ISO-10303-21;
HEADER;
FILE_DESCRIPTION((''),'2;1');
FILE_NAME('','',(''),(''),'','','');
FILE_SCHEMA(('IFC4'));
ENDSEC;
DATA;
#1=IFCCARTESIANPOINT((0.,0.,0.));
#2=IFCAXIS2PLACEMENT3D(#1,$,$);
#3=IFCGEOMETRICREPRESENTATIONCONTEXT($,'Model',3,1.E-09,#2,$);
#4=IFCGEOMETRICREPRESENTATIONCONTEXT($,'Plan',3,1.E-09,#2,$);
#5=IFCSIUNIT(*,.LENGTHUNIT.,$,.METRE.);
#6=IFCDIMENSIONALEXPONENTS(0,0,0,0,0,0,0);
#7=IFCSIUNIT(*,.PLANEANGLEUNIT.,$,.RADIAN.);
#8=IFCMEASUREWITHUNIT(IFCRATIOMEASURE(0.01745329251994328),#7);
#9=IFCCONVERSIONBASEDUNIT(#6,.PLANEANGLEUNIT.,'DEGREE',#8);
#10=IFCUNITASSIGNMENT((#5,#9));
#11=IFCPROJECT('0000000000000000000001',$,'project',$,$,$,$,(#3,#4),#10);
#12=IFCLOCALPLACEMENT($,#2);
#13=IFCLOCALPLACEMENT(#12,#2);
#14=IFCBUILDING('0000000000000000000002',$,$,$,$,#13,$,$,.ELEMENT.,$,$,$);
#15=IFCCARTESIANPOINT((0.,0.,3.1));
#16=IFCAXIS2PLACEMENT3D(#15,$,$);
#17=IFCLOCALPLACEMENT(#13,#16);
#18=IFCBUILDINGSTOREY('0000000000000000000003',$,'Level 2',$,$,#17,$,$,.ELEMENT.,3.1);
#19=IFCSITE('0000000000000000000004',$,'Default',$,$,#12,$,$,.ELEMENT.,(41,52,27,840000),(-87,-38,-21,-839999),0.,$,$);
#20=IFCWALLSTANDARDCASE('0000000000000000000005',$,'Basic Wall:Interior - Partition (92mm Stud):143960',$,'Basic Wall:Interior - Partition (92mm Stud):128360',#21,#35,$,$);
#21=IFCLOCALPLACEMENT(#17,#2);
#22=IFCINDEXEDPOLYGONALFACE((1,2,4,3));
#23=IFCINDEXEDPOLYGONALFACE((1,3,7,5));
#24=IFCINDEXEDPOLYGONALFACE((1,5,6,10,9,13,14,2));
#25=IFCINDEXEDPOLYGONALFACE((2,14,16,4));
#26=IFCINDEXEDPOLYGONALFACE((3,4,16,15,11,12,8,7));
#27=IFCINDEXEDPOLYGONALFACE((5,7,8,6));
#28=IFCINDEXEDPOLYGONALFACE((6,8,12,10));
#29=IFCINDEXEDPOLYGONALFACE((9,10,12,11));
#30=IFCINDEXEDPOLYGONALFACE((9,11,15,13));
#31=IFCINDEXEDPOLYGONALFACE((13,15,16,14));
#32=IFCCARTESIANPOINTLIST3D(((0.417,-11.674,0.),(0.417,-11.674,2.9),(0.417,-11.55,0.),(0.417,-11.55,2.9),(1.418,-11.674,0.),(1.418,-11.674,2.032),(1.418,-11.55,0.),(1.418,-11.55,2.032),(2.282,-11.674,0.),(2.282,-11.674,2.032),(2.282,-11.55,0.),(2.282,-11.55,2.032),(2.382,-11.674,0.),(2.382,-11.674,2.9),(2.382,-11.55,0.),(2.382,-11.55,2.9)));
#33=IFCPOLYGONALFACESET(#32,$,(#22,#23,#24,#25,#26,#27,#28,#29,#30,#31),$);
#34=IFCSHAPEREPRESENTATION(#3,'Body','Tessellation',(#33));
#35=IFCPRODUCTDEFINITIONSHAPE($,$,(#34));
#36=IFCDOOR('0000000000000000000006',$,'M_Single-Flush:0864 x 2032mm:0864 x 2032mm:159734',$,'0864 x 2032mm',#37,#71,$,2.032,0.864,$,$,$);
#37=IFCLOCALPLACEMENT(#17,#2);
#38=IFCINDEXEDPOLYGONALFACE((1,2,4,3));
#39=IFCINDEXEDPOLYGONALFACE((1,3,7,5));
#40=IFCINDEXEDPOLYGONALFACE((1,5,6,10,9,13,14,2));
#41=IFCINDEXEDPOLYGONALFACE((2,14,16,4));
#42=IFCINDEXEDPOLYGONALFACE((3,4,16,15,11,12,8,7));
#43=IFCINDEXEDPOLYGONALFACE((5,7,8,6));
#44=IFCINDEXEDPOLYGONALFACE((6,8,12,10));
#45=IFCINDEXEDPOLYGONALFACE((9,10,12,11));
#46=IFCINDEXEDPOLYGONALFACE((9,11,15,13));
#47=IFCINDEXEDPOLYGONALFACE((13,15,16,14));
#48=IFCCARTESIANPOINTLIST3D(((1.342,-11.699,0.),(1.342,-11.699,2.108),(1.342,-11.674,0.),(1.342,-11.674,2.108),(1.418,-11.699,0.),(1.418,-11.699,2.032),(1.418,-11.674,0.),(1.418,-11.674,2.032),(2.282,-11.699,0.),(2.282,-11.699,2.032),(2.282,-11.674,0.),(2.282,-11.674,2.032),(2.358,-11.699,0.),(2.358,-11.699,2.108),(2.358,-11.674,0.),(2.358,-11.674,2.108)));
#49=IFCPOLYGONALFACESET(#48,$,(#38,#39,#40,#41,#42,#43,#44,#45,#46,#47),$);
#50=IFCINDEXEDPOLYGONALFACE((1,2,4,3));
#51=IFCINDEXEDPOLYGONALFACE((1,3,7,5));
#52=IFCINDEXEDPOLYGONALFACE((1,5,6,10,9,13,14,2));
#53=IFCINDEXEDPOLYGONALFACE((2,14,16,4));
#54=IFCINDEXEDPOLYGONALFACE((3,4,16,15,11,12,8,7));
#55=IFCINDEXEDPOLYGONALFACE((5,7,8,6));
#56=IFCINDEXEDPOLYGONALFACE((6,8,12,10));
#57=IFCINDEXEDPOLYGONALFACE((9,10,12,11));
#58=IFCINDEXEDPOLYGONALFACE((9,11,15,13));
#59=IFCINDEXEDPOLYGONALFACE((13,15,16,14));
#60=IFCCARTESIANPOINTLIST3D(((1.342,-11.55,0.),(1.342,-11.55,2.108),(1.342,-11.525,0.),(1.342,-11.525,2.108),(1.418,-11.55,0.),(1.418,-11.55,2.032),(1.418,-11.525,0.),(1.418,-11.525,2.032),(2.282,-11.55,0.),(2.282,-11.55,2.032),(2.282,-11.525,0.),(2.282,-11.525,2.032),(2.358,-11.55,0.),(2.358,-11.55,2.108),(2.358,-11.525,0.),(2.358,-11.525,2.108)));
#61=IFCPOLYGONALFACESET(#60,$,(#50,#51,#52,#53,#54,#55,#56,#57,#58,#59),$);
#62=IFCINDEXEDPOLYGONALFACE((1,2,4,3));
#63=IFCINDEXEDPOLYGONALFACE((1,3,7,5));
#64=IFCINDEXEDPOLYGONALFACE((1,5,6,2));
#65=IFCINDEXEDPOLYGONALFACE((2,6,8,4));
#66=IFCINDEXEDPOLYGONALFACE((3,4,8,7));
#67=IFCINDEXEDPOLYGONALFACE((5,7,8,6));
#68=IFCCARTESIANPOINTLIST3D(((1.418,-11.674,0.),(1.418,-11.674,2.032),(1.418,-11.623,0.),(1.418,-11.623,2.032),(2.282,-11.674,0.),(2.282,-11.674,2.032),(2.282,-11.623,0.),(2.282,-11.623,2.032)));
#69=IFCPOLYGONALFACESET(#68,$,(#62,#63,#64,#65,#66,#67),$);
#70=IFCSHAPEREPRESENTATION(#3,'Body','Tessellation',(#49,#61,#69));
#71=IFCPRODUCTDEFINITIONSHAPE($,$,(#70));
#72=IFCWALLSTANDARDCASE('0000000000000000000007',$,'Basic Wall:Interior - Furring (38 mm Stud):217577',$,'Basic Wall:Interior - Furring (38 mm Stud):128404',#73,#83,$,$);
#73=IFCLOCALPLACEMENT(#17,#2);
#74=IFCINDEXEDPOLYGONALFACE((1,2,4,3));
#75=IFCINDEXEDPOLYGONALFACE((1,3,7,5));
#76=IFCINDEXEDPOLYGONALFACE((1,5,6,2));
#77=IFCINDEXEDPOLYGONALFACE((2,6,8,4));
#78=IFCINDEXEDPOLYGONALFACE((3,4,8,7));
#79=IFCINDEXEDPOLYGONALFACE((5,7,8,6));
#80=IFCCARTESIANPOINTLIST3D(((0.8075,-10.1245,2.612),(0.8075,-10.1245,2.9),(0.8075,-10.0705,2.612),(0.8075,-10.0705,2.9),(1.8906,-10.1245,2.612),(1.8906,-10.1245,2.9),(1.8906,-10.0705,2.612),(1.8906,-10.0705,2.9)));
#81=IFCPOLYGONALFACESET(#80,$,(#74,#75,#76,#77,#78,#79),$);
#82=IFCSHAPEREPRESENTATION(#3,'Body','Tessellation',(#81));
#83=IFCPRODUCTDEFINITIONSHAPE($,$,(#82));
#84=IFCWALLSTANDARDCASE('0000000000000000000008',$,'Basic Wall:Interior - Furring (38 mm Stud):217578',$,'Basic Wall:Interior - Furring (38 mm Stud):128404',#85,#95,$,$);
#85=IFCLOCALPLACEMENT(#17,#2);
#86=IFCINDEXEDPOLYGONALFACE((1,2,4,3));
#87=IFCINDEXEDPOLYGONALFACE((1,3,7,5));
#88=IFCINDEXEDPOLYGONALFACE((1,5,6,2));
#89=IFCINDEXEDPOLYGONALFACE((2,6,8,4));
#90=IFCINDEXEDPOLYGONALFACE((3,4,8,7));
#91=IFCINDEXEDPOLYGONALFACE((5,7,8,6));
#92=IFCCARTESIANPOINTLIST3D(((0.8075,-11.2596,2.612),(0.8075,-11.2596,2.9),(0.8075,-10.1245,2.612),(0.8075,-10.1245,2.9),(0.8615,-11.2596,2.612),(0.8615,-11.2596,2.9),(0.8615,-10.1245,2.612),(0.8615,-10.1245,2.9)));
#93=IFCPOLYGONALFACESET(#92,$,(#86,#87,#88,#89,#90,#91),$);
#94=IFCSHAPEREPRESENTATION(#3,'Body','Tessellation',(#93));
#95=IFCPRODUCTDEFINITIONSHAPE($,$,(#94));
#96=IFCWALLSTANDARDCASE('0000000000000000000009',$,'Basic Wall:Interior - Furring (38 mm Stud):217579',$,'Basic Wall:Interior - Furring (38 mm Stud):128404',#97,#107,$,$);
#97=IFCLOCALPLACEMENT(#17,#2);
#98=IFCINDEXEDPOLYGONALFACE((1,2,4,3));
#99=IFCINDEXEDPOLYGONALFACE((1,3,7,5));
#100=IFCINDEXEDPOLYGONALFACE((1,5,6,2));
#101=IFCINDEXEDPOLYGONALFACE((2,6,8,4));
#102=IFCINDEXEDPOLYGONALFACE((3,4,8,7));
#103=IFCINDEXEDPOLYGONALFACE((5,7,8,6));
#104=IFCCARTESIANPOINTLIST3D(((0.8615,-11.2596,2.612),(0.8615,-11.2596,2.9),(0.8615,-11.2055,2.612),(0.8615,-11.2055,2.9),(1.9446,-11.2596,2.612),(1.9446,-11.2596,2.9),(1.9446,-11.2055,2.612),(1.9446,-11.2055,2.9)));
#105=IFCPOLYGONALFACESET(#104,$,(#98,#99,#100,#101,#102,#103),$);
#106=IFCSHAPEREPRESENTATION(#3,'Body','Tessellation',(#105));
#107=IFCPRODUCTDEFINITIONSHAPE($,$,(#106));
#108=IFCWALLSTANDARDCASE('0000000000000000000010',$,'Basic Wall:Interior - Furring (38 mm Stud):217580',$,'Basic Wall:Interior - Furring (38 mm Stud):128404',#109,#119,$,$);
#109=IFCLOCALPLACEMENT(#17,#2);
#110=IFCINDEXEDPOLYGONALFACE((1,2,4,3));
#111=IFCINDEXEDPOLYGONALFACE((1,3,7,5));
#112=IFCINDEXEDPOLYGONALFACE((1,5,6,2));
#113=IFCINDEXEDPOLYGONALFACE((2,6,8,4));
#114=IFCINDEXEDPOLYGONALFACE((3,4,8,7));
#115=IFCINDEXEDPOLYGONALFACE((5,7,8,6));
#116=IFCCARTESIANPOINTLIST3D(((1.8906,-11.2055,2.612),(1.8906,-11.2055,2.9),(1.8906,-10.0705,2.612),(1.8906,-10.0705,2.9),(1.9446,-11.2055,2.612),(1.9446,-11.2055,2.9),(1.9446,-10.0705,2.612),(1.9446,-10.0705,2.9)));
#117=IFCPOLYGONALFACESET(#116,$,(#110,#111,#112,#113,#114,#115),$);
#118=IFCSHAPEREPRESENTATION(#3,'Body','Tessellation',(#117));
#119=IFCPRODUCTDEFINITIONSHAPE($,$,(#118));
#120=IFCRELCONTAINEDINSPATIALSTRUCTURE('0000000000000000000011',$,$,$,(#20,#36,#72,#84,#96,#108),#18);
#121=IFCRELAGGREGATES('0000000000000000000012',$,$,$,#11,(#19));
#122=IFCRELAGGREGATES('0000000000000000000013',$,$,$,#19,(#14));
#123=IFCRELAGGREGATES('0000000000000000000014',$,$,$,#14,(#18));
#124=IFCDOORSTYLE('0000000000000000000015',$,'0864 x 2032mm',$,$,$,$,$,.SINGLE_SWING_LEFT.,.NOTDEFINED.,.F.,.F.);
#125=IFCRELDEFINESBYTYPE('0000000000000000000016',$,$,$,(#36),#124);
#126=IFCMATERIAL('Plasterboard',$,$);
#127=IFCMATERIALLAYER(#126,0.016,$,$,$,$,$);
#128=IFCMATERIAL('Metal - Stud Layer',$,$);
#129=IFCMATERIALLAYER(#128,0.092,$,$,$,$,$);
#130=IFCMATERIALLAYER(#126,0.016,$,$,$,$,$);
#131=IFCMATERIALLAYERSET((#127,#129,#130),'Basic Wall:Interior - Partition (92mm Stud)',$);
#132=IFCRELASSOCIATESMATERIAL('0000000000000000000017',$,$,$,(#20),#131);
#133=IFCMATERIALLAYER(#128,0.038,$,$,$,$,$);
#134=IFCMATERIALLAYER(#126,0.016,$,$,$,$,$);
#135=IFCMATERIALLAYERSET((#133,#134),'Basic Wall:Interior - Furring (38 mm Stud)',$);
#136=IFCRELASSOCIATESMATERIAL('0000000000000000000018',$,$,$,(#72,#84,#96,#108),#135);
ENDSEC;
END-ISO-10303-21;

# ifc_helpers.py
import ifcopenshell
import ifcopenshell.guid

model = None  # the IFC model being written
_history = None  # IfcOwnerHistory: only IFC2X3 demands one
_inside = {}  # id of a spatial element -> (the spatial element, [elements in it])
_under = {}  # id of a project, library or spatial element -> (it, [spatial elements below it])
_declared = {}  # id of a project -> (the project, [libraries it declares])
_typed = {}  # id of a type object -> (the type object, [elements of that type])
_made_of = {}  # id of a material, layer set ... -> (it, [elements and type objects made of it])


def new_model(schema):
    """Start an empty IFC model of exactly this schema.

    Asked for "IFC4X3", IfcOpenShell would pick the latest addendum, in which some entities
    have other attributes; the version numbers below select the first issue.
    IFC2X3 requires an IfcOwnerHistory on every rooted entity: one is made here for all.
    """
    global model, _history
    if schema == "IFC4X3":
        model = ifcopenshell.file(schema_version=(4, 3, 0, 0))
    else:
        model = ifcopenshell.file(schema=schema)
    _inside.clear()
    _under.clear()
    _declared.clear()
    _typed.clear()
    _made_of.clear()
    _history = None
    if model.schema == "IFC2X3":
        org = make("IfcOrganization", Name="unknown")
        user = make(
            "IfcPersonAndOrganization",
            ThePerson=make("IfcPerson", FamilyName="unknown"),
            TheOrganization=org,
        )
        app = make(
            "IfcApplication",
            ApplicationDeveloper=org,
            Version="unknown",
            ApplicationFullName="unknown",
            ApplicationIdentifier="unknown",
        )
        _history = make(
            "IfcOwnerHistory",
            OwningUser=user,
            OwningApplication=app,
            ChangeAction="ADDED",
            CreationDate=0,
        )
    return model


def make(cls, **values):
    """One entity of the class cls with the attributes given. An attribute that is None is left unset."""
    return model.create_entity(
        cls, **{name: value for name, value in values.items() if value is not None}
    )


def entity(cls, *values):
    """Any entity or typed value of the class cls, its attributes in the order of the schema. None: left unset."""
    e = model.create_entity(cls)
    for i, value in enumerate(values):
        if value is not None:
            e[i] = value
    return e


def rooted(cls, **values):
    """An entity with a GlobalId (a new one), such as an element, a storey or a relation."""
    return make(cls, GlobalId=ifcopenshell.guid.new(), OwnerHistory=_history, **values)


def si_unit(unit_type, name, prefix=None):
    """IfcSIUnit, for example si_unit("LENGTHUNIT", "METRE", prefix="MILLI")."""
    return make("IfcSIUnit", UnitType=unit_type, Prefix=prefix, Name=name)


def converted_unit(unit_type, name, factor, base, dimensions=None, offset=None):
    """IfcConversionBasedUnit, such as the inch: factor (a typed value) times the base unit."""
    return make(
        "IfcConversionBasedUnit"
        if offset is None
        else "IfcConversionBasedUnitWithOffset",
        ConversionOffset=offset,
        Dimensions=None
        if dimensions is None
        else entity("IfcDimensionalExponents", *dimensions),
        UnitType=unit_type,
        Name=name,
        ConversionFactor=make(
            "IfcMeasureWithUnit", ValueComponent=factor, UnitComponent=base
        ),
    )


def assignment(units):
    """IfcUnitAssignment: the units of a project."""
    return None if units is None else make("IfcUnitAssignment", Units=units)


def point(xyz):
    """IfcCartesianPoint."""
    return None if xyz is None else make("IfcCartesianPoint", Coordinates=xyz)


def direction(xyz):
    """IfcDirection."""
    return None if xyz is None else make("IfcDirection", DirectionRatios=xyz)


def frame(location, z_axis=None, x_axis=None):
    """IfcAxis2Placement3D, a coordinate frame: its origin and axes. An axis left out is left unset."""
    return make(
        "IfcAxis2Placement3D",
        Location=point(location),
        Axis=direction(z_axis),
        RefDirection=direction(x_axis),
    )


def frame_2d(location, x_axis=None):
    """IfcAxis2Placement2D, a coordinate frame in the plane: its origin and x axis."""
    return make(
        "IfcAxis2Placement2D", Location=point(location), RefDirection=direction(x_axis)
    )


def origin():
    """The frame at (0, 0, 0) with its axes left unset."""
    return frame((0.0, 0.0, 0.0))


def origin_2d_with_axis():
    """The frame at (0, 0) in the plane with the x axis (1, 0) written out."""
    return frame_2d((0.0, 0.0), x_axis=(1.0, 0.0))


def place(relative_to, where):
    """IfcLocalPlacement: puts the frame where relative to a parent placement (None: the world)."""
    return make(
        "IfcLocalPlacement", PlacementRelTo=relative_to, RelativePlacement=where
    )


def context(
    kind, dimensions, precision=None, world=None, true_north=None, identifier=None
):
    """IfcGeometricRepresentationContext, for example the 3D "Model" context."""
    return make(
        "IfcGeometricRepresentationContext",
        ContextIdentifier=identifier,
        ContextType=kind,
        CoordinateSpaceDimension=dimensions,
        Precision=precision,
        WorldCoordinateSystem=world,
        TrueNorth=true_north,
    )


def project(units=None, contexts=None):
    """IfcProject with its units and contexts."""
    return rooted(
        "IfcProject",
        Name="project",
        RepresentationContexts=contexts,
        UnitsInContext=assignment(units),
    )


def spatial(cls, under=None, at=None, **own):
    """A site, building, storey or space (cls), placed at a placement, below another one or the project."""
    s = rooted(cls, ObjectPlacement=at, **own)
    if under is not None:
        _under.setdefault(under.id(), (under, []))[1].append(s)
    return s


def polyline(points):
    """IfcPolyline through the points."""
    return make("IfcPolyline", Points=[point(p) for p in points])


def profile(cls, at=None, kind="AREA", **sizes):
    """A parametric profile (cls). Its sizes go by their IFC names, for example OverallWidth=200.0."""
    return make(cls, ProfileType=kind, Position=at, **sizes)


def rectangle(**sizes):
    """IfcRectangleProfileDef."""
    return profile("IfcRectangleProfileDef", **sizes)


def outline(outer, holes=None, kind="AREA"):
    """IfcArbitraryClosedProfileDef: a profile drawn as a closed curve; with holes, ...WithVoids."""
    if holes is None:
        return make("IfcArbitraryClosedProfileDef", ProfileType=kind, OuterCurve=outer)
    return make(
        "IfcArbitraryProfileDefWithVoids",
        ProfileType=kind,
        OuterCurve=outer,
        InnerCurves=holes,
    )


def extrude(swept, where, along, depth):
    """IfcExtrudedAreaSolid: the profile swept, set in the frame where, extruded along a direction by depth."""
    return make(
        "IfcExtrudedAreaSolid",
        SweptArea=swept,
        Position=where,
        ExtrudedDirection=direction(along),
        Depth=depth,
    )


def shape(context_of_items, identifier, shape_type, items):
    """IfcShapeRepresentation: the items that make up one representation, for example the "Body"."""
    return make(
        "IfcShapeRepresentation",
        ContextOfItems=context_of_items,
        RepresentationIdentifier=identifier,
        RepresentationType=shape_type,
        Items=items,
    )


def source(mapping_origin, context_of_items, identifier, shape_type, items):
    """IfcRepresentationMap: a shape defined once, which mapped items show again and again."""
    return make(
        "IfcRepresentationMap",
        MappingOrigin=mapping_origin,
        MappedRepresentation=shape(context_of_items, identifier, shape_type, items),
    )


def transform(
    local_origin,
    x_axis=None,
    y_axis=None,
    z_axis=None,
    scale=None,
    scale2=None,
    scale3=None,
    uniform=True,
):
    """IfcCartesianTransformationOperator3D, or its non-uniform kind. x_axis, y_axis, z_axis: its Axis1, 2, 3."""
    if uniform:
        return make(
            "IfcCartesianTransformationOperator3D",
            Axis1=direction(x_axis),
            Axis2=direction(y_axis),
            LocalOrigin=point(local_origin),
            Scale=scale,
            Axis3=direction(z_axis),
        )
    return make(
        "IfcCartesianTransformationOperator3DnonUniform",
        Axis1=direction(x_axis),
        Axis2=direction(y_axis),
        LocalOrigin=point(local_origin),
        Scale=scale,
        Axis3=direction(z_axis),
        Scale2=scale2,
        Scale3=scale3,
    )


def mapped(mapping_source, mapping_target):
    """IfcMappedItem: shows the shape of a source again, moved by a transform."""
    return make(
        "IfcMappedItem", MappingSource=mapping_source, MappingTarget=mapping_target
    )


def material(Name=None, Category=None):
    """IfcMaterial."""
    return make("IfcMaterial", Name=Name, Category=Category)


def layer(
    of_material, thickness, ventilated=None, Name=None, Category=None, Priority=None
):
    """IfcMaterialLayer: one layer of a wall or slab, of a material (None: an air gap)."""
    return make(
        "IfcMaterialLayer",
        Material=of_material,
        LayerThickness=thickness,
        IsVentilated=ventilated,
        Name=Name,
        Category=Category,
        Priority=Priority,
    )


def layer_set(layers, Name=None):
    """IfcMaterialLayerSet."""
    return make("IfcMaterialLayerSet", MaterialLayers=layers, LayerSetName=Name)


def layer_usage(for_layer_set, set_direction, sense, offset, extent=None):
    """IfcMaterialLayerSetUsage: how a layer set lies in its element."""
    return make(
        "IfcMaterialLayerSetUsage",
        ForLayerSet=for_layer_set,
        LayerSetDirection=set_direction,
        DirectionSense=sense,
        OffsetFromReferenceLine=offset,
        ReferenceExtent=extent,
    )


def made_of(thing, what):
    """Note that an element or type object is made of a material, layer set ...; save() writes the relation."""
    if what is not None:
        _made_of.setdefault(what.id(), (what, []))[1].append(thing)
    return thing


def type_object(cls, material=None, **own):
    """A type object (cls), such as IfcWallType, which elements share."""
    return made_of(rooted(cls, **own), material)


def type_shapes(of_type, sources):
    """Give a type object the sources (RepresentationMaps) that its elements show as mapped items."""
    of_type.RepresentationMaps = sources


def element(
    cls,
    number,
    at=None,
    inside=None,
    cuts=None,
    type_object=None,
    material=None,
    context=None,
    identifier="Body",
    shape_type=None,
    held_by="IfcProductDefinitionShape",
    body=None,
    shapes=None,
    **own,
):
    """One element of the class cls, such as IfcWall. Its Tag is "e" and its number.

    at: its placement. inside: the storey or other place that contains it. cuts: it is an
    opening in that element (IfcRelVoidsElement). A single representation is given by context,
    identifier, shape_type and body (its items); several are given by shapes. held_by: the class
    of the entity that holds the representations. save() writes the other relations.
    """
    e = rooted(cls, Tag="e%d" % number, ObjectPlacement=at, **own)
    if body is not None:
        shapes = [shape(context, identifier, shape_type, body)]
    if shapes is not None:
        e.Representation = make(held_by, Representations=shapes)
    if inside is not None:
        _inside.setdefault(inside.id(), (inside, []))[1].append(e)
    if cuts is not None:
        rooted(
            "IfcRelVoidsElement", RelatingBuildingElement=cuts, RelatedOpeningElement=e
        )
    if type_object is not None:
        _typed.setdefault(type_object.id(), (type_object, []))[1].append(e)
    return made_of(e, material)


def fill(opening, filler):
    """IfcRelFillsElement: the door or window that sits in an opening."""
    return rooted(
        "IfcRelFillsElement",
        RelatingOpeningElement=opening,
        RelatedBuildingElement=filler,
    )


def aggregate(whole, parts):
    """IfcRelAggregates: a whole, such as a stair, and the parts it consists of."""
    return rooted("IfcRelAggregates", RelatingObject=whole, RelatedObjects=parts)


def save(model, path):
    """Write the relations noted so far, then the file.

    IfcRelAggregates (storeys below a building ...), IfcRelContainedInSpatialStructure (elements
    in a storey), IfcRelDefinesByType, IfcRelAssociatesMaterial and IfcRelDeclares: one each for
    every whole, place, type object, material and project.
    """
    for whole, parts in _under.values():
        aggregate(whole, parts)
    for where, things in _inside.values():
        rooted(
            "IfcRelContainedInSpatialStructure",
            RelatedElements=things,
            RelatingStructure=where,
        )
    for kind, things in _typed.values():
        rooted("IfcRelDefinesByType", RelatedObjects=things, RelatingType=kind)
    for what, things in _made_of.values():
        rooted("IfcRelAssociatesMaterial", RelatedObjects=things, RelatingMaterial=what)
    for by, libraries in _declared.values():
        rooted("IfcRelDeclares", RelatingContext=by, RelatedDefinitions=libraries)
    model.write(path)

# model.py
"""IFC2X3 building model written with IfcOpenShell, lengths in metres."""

from ifc_helpers import new_model, entity, si_unit, converted_unit, frame, frame_2d, origin, origin_2d_with_axis, place, context, project, spatial, polyline, rectangle, outline, extrude, source, transform, mapped, material, layer, layer_set, layer_usage, type_object, type_shapes, element, fill, save


model = new_model("IFC2X3")

# Units and contexts
model_context = context("Model", 3, precision=1e-09, world=origin())
plan_context = context("Plan", 3, precision=1e-09, world=origin())
ifc_project = project(units=[si_unit("LENGTHUNIT", "METRE"), converted_unit("PLANEANGLEUNIT", "DEGREE", entity("IfcRatioMeasure", 0.01745329251994328), si_unit("PLANEANGLEUNIT", "RADIAN"), dimensions=[0, 0, 0, 0, 0, 0, 0])], contexts=[model_context, plan_context])

# Site, building, storey
site_placement = place(None, origin())
site = spatial("IfcSite", under=ifc_project, at=site_placement, Name="Default", CompositionType="ELEMENT", RefLatitude=(41, 52, 27, 840000), RefLongitude=(-87, -38, -21, -839999), RefElevation=0.0)
building_placement = place(site_placement, origin())
building = spatial("IfcBuilding", under=site, at=building_placement, CompositionType="ELEMENT")
storey_placement = place(building_placement, frame((0.0, 0.0, 3.1)))
storey = spatial("IfcBuildingStorey", under=building, at=storey_placement, Name="Level 2", CompositionType="ELEMENT", Elevation=3.1)

# Wall, opening, door
ifc_material_1 = material(Name="Plasterboard")
ifc_layer_1 = layer(ifc_material_1, 0.016)
ifc_material_2 = material(Name="Metal - Stud Layer")
ifc_layer_2 = layer(ifc_material_2, 0.092)
ifc_layer_3 = layer(ifc_material_1, 0.016)
ifc_layer_set_1 = layer_set([ifc_layer_1, ifc_layer_2, ifc_layer_3], Name="Basic Wall:Interior - Partition (92mm Stud)")
ifc_layer_usage_1 = layer_usage(ifc_layer_set_1, "AXIS2", "NEGATIVE", 0.062)
wall_1_placement = place(storey_placement, frame((2.382, -11.612, 0.0), z_axis=(0.0, 0.0, 1.0), x_axis=(-1.0, 0.0, 0.0)))
wall_1 = element("IfcWallStandardCase", 1, at=wall_1_placement, inside=storey, material=ifc_layer_usage_1, Name="Basic Wall:Interior - Partition (92mm Stud):143960", ObjectType="Basic Wall:Interior - Partition (92mm Stud):128360", context=model_context, shape_type="SweptSolid", body=[
    extrude(rectangle(XDim=1.965, YDim=0.124, at=frame_2d((0.9825, 0.0), x_axis=(-1.0, 0.0))), origin(), (0.0, 0.0, 1.0), 2.9),
])
opening_placement = place(wall_1_placement, frame((0.1, -0.062, 0.0)))
opening = element("IfcOpeningElement", 2, at=opening_placement, cuts=wall_1, ObjectType="Opening", context=model_context, shape_type="SweptSolid", body=[
    extrude(rectangle(XDim=0.864, YDim=2.032, at=frame_2d((1.016, 0.432), x_axis=(0.0, -1.0))), frame((0.0, 0.0, 0.0), z_axis=(0.0, 1.0, 0.0), x_axis=(0.0, 0.0, 1.0)), (0.0, 0.0, 1.0), 0.124),
])
door_style = type_object("IfcDoorStyle", Name="0864 x 2032mm", ConstructionType="NOTDEFINED", OperationType="SINGLE_SWING_LEFT", ParameterTakesPrecedence=False, Sizeable=False)
shared_shape = source(origin(), model_context, "Body", "SweptSolid", [
    extrude(outline(polyline([(-0.508, -1.073), (0.508, -1.073), (0.508, 1.035), (0.432, 1.035), (0.432, -0.997), (-0.432, -0.997), (-0.432, 1.035), (-0.508, 1.035), (-0.508, -1.073)])), frame((0.432, 0.149, 1.035), z_axis=(0.0, -1.0, 0.0), x_axis=(-1.0, 0.0, 0.0)), (0.0, 0.0, 1.0), 0.025),
    extrude(outline(polyline([(-1.073, -0.508), (1.035, -0.508), (1.035, -0.432), (-0.997, -0.432), (-0.997, 0.432), (1.035, 0.432), (1.035, 0.508), (-1.073, 0.508), (-1.073, -0.508)])), frame((0.432, 0.0, 1.035), z_axis=(0.0, -1.0, 0.0), x_axis=(0.0, 0.0, -1.0)), (0.0, 0.0, 1.0), 0.025),
    extrude(rectangle(XDim=0.864, YDim=0.051, at=origin_2d_with_axis()), frame((0.432, 0.0985, 0.0)), (0.0, 0.0, 1.0), 2.032),
])
type_shapes(door_style, [shared_shape])
door_placement = place(opening_placement, origin())
door = element("IfcDoor", 3, at=door_placement, inside=storey, type_object=door_style, Name="M_Single-Flush:0864 x 2032mm:0864 x 2032mm:159734", ObjectType="0864 x 2032mm", OverallHeight=2.032, OverallWidth=0.864, context=model_context, shape_type="MappedRepresentation", body=[
    mapped(shared_shape, transform((0.0, 0.0, 0.0), scale=1.0)),
])
fill(opening, door)

# Walls
ifc_layer_4 = layer(ifc_material_2, 0.038)
ifc_layer_5 = layer(ifc_material_1, 0.016)
ifc_layer_set_2 = layer_set([ifc_layer_4, ifc_layer_5], Name="Basic Wall:Interior - Furring (38 mm Stud)")
ifc_layer_usage_2 = layer_usage(ifc_layer_set_2, "AXIS2", "NEGATIVE", 0.027)
wall_2_placement = place(storey_placement, frame((0.8075, -10.0975, 2.612)))
element("IfcWallStandardCase", 4, at=wall_2_placement, inside=storey, material=ifc_layer_usage_2, Name="Basic Wall:Interior - Furring (38 mm Stud):217577", ObjectType="Basic Wall:Interior - Furring (38 mm Stud):128404", context=model_context, shape_type="SweptSolid", body=[
    extrude(rectangle(XDim=1.0831, YDim=0.054, at=frame_2d((0.5415, 0.0), x_axis=(-1.0, 0.0))), origin(), (0.0, 0.0, 1.0), 0.288),
])
ifc_layer_usage_3 = layer_usage(ifc_layer_set_2, "AXIS2", "NEGATIVE", 0.027)
wall_3_placement = place(storey_placement, frame((0.8345, -11.2596, 2.612), z_axis=(0.0, 0.0, 1.0), x_axis=(0.0, 1.0, 0.0)))
element("IfcWallStandardCase", 5, at=wall_3_placement, inside=storey, material=ifc_layer_usage_3, Name="Basic Wall:Interior - Furring (38 mm Stud):217578", ObjectType="Basic Wall:Interior - Furring (38 mm Stud):128404", context=model_context, shape_type="SweptSolid", body=[
    extrude(rectangle(XDim=1.1351, YDim=0.054, at=frame_2d((0.5675, 0.0), x_axis=(-1.0, 0.0))), origin(), (0.0, 0.0, 1.0), 0.288),
])
ifc_layer_usage_4 = layer_usage(ifc_layer_set_2, "AXIS2", "NEGATIVE", 0.027)
wall_4_placement = place(storey_placement, frame((1.9446, -11.2325, 2.612), z_axis=(0.0, 0.0, 1.0), x_axis=(-1.0, 0.0, 0.0)))
element("IfcWallStandardCase", 6, at=wall_4_placement, inside=storey, material=ifc_layer_usage_4, Name="Basic Wall:Interior - Furring (38 mm Stud):217579", ObjectType="Basic Wall:Interior - Furring (38 mm Stud):128404", context=model_context, shape_type="SweptSolid", body=[
    extrude(rectangle(XDim=1.0831, YDim=0.054, at=frame_2d((0.5415, 0.0), x_axis=(-1.0, 0.0))), origin(), (0.0, 0.0, 1.0), 0.288),
])
ifc_layer_usage_5 = layer_usage(ifc_layer_set_2, "AXIS2", "NEGATIVE", 0.027)
wall_5_placement = place(storey_placement, frame((1.9176, -10.0705, 2.612), z_axis=(0.0, 0.0, 1.0), x_axis=(0.0, -1.0, 0.0)))
element("IfcWallStandardCase", 7, at=wall_5_placement, inside=storey, material=ifc_layer_usage_5, Name="Basic Wall:Interior - Furring (38 mm Stud):217580", ObjectType="Basic Wall:Interior - Furring (38 mm Stud):128404", context=model_context, shape_type="SweptSolid", body=[
    extrude(rectangle(XDim=1.1351, YDim=0.054, at=frame_2d((0.5675, 0.0), x_axis=(-1.0, 0.0))), origin(), (0.0, 0.0, 1.0), 0.288),
])

save(model, "model.ifc")
